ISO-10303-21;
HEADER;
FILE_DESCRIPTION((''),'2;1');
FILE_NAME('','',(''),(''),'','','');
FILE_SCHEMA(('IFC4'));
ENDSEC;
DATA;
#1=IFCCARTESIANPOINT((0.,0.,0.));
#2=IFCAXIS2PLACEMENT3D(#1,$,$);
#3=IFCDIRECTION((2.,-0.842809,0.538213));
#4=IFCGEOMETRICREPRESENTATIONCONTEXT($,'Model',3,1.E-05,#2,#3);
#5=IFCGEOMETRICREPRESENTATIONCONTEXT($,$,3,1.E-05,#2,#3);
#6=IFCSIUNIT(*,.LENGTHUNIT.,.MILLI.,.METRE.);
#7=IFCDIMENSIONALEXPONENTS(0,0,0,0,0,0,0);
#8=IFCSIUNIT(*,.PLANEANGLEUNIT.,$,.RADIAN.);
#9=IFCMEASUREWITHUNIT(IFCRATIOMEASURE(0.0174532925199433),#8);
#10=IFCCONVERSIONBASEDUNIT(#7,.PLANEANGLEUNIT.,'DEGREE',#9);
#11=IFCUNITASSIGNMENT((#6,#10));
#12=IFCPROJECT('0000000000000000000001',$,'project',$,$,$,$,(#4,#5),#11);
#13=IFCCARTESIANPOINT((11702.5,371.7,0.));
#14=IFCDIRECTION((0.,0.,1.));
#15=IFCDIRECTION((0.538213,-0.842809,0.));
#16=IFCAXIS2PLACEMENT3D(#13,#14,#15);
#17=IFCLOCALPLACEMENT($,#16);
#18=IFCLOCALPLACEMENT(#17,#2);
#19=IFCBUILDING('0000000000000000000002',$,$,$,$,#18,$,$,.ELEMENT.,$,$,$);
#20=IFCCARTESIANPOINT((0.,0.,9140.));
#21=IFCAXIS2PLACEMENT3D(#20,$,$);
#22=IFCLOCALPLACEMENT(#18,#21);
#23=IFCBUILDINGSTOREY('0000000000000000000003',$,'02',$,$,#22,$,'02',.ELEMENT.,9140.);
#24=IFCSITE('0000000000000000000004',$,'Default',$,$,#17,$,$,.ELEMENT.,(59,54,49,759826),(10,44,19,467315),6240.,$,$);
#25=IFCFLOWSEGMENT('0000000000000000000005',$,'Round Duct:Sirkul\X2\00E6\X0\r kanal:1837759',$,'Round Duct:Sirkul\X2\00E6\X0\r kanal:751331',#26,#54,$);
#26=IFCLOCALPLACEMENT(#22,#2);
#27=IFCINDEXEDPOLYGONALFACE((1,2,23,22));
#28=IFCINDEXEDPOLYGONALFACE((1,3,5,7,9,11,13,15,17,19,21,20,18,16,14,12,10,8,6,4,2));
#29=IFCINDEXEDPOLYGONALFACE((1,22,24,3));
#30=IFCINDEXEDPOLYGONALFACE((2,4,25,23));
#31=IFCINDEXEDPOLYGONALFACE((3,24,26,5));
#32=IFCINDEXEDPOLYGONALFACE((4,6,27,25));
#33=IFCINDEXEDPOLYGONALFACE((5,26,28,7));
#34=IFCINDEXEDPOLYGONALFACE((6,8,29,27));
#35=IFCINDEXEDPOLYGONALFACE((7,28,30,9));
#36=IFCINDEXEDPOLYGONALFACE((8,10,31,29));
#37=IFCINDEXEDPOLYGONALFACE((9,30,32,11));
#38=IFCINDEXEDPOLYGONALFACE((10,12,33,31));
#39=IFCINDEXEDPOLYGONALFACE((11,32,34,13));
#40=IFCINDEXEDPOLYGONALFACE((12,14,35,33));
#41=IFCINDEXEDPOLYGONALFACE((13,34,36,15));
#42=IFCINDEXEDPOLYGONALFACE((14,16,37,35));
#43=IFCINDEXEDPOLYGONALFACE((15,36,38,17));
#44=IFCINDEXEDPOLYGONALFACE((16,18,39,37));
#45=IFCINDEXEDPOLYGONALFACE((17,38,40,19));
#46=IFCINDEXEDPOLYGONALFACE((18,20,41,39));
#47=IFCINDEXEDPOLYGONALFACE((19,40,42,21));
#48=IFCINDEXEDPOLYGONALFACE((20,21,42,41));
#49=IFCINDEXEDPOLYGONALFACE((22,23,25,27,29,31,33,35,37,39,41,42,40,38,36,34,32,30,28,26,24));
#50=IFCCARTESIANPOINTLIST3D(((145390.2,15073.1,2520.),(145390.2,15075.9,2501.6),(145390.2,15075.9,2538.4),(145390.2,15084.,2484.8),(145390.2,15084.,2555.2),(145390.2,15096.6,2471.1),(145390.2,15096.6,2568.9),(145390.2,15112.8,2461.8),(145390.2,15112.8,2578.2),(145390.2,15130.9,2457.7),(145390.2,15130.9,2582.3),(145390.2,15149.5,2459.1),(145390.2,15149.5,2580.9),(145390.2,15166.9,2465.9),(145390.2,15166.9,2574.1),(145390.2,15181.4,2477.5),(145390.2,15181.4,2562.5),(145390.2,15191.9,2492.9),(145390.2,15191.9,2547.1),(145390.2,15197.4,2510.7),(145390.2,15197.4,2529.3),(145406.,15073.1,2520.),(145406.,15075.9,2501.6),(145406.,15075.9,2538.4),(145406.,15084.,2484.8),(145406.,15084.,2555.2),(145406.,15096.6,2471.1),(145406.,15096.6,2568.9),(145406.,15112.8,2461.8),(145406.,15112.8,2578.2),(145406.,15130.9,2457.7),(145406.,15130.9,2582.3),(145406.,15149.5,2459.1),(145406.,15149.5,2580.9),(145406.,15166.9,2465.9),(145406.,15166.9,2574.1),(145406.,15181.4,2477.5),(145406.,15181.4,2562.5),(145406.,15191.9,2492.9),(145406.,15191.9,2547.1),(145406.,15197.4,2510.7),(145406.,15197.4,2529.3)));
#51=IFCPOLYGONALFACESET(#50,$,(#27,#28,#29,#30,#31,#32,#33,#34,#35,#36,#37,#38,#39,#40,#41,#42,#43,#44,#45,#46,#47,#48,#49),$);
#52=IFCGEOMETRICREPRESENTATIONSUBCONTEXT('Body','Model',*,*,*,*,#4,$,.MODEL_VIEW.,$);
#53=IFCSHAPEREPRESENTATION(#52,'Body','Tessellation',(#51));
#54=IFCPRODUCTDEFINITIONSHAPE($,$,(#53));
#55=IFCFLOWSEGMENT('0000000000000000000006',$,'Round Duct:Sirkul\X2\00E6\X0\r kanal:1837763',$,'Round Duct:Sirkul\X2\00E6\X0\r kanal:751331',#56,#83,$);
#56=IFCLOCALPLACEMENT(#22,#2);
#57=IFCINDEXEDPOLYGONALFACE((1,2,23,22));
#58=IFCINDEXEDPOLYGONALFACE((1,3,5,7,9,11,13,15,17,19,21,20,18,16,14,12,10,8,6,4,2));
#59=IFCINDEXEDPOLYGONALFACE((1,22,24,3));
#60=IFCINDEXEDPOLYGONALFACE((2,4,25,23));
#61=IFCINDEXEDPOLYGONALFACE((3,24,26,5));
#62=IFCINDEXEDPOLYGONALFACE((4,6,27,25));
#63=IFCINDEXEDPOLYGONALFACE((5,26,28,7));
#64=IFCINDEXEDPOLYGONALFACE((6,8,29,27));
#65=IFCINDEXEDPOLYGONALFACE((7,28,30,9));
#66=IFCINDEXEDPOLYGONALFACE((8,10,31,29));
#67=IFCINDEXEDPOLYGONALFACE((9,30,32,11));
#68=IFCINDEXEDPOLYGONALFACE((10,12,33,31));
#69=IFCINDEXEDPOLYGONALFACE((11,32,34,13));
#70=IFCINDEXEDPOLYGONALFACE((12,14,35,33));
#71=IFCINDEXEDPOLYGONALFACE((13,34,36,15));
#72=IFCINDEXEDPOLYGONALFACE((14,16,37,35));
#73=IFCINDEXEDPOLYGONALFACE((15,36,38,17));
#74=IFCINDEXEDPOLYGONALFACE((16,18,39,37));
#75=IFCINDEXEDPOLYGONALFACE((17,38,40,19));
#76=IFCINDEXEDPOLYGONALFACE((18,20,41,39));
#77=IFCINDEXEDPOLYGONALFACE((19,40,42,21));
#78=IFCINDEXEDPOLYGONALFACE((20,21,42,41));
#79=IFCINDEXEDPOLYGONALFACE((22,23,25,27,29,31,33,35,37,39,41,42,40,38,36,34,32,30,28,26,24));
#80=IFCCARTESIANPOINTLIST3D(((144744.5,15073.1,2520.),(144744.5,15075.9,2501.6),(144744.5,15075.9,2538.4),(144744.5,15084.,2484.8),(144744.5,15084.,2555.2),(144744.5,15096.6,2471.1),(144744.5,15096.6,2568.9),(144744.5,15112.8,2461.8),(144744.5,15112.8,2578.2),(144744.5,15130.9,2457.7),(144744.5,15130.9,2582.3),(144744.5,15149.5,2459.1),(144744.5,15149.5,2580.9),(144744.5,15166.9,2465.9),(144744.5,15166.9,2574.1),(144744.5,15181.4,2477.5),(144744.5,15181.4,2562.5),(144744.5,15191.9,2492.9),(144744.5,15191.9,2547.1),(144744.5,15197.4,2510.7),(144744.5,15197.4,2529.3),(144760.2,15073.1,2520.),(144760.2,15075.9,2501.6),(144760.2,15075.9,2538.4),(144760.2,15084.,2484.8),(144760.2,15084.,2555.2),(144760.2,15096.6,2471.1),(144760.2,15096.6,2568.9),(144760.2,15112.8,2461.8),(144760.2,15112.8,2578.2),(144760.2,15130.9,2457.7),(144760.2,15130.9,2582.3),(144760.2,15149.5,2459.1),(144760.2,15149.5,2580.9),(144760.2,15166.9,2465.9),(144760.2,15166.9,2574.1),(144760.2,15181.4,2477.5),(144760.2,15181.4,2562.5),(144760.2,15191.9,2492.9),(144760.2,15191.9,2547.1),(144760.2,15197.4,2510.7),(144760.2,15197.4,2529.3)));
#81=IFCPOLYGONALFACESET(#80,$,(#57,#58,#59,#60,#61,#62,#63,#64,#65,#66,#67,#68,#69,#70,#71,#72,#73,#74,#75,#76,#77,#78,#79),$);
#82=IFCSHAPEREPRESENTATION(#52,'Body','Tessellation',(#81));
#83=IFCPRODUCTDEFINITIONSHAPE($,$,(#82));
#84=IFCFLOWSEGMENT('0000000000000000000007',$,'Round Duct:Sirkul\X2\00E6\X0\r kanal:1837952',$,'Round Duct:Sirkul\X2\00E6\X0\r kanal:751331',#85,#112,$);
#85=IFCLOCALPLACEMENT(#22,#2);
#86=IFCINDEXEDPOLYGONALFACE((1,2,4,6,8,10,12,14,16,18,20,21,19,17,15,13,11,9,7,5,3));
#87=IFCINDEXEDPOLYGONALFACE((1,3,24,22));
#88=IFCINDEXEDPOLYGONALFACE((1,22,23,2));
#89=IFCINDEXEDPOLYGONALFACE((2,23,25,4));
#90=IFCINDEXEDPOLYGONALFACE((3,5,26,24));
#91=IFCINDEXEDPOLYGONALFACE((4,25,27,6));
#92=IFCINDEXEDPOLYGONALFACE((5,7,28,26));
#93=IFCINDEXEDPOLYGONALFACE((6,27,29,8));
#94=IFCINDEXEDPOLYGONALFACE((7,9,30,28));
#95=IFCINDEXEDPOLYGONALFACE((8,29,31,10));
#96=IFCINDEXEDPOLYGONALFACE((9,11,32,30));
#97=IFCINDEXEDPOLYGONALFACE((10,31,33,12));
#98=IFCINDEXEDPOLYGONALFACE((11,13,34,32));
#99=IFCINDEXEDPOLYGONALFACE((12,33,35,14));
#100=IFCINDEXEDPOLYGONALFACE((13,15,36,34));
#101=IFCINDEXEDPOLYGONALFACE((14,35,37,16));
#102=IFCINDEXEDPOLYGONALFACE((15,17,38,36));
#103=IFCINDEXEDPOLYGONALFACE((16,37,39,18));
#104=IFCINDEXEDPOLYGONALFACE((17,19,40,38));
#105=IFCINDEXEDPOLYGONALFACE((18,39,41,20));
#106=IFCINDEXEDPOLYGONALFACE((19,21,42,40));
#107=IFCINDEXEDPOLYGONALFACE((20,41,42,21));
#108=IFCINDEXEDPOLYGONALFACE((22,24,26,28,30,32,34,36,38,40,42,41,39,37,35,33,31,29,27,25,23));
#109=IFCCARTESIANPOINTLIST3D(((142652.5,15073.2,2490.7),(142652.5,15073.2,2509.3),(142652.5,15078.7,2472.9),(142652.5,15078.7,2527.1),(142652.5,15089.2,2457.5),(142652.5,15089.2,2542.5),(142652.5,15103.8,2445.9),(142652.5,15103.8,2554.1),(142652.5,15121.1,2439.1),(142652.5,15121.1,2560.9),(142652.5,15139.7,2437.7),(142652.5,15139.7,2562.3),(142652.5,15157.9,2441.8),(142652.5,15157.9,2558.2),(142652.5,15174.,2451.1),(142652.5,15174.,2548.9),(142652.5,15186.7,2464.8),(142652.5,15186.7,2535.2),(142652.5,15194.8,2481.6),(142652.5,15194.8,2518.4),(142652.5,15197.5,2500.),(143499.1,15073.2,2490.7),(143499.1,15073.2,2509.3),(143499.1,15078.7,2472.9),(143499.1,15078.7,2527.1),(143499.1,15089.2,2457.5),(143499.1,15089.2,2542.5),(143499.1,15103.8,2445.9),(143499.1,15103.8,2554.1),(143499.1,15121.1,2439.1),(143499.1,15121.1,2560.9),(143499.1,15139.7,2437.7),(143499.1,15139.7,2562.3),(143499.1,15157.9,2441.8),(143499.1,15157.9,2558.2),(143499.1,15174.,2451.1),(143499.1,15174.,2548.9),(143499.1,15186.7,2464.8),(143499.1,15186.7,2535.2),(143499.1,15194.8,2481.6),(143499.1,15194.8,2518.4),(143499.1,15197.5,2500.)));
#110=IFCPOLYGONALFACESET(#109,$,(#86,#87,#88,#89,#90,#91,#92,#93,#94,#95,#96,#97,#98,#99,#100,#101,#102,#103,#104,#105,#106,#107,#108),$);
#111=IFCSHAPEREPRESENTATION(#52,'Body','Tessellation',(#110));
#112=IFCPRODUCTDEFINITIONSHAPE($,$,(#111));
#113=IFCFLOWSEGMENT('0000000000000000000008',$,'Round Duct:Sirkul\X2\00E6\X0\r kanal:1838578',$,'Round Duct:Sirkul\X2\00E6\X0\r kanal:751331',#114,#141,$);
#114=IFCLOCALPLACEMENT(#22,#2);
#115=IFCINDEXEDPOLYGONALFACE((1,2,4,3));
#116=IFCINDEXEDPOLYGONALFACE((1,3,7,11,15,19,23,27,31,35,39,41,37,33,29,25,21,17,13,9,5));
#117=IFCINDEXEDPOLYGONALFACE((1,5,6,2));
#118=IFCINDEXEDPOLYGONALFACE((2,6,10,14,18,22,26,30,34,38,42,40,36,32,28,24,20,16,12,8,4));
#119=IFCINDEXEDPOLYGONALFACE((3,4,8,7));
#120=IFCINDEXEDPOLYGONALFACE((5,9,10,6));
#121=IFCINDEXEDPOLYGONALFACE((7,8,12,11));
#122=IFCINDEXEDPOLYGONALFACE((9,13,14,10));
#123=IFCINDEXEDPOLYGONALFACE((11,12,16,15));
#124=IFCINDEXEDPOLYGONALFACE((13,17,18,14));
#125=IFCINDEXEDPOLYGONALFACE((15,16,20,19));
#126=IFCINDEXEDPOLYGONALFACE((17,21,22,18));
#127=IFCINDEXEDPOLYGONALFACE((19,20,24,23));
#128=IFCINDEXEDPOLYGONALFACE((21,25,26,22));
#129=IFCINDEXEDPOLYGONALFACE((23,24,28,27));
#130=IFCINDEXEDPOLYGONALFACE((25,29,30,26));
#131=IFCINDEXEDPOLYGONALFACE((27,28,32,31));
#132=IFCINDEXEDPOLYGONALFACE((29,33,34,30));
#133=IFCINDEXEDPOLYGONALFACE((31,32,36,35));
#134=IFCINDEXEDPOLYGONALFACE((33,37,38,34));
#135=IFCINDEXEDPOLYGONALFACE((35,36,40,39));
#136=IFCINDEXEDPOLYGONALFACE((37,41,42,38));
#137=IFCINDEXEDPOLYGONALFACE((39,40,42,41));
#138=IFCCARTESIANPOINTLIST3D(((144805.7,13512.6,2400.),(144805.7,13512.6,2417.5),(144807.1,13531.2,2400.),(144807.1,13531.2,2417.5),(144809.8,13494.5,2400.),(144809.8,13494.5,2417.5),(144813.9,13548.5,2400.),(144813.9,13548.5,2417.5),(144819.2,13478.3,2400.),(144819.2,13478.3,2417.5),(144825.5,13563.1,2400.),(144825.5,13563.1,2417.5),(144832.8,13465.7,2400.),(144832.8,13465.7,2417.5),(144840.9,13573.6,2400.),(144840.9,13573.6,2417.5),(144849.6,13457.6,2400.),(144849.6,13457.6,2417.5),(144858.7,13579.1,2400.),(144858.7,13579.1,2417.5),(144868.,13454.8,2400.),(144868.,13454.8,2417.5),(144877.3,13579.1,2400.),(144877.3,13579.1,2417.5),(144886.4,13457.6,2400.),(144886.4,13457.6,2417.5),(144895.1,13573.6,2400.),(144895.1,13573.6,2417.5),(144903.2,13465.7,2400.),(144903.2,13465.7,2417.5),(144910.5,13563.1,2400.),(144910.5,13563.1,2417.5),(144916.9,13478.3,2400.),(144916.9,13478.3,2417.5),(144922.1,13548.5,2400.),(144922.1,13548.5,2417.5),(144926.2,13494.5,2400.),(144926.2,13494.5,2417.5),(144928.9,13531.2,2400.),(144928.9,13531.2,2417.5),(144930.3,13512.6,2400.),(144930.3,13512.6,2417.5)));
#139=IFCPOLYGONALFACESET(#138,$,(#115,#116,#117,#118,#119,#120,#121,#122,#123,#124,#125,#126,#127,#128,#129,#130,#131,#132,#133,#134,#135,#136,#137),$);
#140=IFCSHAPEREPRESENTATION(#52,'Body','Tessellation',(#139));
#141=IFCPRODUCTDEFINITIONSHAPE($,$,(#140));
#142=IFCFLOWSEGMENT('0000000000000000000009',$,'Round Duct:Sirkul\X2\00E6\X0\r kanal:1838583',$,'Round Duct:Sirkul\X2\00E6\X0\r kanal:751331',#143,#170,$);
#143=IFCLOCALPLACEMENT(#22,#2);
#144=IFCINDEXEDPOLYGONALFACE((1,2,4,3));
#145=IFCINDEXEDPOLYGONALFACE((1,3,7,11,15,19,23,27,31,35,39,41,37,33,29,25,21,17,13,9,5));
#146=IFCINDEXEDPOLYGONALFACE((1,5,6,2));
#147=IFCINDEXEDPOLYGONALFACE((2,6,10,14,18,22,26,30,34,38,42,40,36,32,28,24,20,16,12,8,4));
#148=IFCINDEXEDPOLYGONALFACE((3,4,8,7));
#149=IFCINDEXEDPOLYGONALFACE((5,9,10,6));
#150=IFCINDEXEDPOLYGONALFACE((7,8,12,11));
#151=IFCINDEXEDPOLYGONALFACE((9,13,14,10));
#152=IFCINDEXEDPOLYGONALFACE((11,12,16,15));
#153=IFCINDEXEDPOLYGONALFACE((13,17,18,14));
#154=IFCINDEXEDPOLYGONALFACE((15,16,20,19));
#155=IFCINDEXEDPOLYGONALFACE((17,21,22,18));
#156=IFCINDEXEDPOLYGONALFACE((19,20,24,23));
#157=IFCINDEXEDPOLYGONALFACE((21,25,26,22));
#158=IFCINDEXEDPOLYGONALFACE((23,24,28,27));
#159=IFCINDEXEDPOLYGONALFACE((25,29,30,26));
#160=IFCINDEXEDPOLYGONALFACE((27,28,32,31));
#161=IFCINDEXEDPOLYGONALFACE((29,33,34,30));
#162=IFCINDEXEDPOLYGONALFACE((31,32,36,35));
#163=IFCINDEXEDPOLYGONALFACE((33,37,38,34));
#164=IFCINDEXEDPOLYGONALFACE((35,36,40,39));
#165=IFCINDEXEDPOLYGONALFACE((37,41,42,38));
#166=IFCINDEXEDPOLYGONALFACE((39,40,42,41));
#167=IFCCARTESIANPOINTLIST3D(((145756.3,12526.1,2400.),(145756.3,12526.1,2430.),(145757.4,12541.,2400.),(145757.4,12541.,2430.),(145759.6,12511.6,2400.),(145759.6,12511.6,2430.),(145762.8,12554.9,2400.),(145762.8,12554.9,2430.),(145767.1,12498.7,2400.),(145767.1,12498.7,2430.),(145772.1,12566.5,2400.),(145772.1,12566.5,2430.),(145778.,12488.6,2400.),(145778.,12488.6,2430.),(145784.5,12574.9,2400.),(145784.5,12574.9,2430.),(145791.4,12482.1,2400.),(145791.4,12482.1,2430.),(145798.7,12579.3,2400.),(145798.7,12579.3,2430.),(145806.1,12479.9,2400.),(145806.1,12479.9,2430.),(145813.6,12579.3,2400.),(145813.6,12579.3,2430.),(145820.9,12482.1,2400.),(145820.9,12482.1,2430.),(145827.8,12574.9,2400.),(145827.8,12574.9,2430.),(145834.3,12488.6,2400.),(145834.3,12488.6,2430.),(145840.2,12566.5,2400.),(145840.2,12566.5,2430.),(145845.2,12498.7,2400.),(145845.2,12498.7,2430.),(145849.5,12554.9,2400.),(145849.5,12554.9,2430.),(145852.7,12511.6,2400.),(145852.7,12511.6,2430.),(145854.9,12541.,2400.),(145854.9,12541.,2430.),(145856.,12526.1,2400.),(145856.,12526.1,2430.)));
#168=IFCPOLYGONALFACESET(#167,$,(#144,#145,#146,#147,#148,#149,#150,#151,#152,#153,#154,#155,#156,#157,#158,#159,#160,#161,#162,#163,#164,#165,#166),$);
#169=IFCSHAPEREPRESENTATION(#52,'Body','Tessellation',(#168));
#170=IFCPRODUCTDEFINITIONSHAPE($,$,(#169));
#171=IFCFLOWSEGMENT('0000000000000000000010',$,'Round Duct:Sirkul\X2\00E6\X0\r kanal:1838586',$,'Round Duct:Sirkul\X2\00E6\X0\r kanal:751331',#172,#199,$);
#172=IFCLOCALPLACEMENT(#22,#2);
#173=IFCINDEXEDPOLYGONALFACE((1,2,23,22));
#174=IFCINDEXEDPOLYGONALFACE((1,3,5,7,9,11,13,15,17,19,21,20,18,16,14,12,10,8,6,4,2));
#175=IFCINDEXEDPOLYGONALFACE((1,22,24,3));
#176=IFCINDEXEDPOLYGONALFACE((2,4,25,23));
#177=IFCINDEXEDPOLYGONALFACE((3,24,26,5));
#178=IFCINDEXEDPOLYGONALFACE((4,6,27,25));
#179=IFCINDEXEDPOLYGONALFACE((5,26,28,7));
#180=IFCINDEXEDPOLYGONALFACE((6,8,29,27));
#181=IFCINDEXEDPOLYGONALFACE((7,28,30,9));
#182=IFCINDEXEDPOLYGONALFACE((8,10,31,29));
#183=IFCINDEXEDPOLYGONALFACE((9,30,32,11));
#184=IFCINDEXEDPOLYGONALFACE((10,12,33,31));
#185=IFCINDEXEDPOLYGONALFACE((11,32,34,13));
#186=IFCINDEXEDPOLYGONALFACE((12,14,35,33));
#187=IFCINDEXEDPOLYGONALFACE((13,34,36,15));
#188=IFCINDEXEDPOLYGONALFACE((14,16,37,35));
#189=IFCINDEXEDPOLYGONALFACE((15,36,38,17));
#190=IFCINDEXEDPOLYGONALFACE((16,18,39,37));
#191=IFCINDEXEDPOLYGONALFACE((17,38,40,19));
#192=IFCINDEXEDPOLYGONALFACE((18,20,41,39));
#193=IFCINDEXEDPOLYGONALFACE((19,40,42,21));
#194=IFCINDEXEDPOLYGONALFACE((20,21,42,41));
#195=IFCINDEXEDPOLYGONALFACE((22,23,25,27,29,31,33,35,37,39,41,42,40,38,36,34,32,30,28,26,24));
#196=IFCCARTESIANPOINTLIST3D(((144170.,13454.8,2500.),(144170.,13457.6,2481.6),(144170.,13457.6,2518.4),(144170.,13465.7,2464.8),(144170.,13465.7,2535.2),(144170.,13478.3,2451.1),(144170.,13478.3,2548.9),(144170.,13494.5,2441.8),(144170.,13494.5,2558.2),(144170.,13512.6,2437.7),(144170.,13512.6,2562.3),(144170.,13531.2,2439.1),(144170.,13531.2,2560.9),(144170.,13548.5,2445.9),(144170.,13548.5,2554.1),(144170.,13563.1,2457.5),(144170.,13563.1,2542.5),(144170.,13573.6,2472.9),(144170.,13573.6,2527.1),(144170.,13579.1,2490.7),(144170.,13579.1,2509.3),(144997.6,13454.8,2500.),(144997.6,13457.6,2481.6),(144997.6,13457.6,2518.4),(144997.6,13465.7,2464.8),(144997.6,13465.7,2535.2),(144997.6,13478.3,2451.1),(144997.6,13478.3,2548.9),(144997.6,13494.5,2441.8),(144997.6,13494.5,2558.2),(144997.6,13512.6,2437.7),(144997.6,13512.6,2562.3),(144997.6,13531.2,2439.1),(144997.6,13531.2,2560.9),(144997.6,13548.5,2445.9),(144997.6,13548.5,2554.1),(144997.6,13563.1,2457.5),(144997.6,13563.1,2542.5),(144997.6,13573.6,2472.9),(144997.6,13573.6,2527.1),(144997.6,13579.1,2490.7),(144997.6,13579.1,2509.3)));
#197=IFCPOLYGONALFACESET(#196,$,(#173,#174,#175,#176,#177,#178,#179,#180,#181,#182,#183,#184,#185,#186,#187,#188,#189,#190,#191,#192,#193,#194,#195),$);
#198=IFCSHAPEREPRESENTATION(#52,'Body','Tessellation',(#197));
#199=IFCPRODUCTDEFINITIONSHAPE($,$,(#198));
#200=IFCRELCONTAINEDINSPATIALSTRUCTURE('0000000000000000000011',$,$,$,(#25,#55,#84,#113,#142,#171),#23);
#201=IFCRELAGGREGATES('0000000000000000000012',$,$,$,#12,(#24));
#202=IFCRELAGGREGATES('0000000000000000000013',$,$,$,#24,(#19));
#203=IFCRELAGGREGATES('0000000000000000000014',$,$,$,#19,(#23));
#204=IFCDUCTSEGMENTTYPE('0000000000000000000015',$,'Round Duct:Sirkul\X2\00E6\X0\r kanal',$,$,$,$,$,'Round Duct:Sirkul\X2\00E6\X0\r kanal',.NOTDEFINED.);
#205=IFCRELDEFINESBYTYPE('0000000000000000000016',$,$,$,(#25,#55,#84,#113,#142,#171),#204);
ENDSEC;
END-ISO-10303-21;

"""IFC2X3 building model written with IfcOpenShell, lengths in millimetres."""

from ifc_helpers import new_model, entity, si_unit, converted_unit, direction, frame, frame_2d, origin, origin_2d_with_axis, place, context, subcontext, project, spatial, circle, extrude, type_object, element, save


model = new_model("IFC2X3")

# Units and contexts
model_context = context("Model", 3, precision=1e-05, world=origin(), true_north=direction((2.0, -0.842809, 0.538213)))
context_of_model = context(None, 3, precision=1e-05, world=origin(), true_north=direction((2.0, -0.842809, 0.538213)))
body_context = subcontext(model_context, "Body", "Model", "MODEL_VIEW")
ifc_project = project(units=[si_unit("LENGTHUNIT", "METRE", prefix="MILLI"), converted_unit("PLANEANGLEUNIT", "DEGREE", entity("IfcRatioMeasure", 0.0174532925199433), si_unit("PLANEANGLEUNIT", "RADIAN"), dimensions=[0, 0, 0, 0, 0, 0, 0])], contexts=[model_context, context_of_model])

# Site, building, storey
site_placement = place(None, frame((11702.5, 371.7, 0.0), z_axis=(0.0, 0.0, 1.0), x_axis=(0.538213, -0.842809, 0.0)))
site = spatial("IfcSite", under=ifc_project, at=site_placement, Name="Default", CompositionType="ELEMENT", RefLatitude=(59, 54, 49, 759826), RefLongitude=(10, 44, 19, 467315), RefElevation=6240.0)
building_placement = place(site_placement, origin())
building = spatial("IfcBuilding", under=site, at=building_placement, CompositionType="ELEMENT")
storey_placement = place(building_placement, frame((0.0, 0.0, 9140.0)))
storey = spatial("IfcBuildingStorey", under=building, at=storey_placement, Name="02", LongName="02", CompositionType="ELEMENT", Elevation=9140.0)

# Flow segments
duct_segment_type_1 = type_object("IfcDuctSegmentType", Name="Round Duct:Sirkulær kanal", ElementType="Round Duct:Sirkulær kanal", PredefinedType="NOTDEFINED")
flow_segment_1_placement = place(storey_placement, origin())
element("IfcFlowSegment", 1, at=flow_segment_1_placement, inside=storey, type_object=duct_segment_type_1, Name="Round Duct:Sirkulær kanal:1837759", ObjectType="Round Duct:Sirkulær kanal:751331", context=body_context, shape_type="SweptSolid", body=[
    extrude(circle(Radius=62.5, at=origin_2d_with_axis()), frame((145390.2, 15135.6, 2520.0), z_axis=(1.0, 0.0, 0.0), x_axis=(0.0, -1.0, 0.0)), (0.0, 0.0, 1.0), 15.7),
])
flow_segment_2_placement = place(storey_placement, origin())
element("IfcFlowSegment", 2, at=flow_segment_2_placement, inside=storey, type_object=duct_segment_type_1, Name="Round Duct:Sirkulær kanal:1837763", ObjectType="Round Duct:Sirkulær kanal:751331", context=body_context, shape_type="SweptSolid", body=[
    extrude(circle(Radius=62.5, at=origin_2d_with_axis()), frame((144744.5, 15135.6, 2520.0), z_axis=(1.0, 0.0, 0.0), x_axis=(0.0, -1.0, 0.0)), (0.0, 0.0, 1.0), 15.7),
])
flow_segment_3_placement = place(storey_placement, origin())
element("IfcFlowSegment", 3, at=flow_segment_3_placement, inside=storey, type_object=duct_segment_type_1, Name="Round Duct:Sirkulær kanal:1837952", ObjectType="Round Duct:Sirkulær kanal:751331", context=body_context, shape_type="SweptSolid", body=[
    extrude(circle(Radius=62.5, at=origin_2d_with_axis()), frame((142652.5, 15135.0, 2500.0), z_axis=(1.0, 0.0, 0.0), x_axis=(0.0, 1.0, 0.0)), (0.0, 0.0, 1.0), 846.5),
])
flow_segment_4_placement = place(storey_placement, origin())
element("IfcFlowSegment", 4, at=flow_segment_4_placement, inside=storey, type_object=duct_segment_type_1, Name="Round Duct:Sirkulær kanal:1838578", ObjectType="Round Duct:Sirkulær kanal:751331", context=body_context, shape_type="SweptSolid", body=[
    extrude(circle(Radius=62.5, at=frame_2d((0.0, 0.0), x_axis=(1.0, 0.0))), frame((144868.0, 13517.3, 2400.0), z_axis=(0.0, 0.0, 1.0), x_axis=(0.0, -1.0, 0.0)), (0.0, 0.0, 1.0), 17.5),
])
flow_segment_5_placement = place(storey_placement, origin())
element("IfcFlowSegment", 5, at=flow_segment_5_placement, inside=storey, type_object=duct_segment_type_1, Name="Round Duct:Sirkulær kanal:1838583", ObjectType="Round Duct:Sirkulær kanal:751331", context=body_context, shape_type="SweptSolid", body=[
    extrude(circle(Radius=50.0, at=frame_2d((0.0, 0.0), x_axis=(1.0, 0.0))), frame((145806.1, 12529.9, 2400.0), z_axis=(0.0, 0.0, 1.0), x_axis=(0.0, -1.0, 0.0)), (0.0, 0.0, 1.0), 30.0),
])
flow_segment_6_placement = place(storey_placement, origin())
element("IfcFlowSegment", 6, at=flow_segment_6_placement, inside=storey, type_object=duct_segment_type_1, Name="Round Duct:Sirkulær kanal:1838586", ObjectType="Round Duct:Sirkulær kanal:751331", context=body_context, shape_type="SweptSolid", body=[
    extrude(circle(Radius=62.5, at=origin_2d_with_axis()), frame((144170.0, 13517.3, 2500.0), z_axis=(1.0, 0.0, 0.0), x_axis=(0.0, -1.0, 0.0)), (0.0, 0.0, 1.0), 827.6),
])

save(model, "model.ifc")
